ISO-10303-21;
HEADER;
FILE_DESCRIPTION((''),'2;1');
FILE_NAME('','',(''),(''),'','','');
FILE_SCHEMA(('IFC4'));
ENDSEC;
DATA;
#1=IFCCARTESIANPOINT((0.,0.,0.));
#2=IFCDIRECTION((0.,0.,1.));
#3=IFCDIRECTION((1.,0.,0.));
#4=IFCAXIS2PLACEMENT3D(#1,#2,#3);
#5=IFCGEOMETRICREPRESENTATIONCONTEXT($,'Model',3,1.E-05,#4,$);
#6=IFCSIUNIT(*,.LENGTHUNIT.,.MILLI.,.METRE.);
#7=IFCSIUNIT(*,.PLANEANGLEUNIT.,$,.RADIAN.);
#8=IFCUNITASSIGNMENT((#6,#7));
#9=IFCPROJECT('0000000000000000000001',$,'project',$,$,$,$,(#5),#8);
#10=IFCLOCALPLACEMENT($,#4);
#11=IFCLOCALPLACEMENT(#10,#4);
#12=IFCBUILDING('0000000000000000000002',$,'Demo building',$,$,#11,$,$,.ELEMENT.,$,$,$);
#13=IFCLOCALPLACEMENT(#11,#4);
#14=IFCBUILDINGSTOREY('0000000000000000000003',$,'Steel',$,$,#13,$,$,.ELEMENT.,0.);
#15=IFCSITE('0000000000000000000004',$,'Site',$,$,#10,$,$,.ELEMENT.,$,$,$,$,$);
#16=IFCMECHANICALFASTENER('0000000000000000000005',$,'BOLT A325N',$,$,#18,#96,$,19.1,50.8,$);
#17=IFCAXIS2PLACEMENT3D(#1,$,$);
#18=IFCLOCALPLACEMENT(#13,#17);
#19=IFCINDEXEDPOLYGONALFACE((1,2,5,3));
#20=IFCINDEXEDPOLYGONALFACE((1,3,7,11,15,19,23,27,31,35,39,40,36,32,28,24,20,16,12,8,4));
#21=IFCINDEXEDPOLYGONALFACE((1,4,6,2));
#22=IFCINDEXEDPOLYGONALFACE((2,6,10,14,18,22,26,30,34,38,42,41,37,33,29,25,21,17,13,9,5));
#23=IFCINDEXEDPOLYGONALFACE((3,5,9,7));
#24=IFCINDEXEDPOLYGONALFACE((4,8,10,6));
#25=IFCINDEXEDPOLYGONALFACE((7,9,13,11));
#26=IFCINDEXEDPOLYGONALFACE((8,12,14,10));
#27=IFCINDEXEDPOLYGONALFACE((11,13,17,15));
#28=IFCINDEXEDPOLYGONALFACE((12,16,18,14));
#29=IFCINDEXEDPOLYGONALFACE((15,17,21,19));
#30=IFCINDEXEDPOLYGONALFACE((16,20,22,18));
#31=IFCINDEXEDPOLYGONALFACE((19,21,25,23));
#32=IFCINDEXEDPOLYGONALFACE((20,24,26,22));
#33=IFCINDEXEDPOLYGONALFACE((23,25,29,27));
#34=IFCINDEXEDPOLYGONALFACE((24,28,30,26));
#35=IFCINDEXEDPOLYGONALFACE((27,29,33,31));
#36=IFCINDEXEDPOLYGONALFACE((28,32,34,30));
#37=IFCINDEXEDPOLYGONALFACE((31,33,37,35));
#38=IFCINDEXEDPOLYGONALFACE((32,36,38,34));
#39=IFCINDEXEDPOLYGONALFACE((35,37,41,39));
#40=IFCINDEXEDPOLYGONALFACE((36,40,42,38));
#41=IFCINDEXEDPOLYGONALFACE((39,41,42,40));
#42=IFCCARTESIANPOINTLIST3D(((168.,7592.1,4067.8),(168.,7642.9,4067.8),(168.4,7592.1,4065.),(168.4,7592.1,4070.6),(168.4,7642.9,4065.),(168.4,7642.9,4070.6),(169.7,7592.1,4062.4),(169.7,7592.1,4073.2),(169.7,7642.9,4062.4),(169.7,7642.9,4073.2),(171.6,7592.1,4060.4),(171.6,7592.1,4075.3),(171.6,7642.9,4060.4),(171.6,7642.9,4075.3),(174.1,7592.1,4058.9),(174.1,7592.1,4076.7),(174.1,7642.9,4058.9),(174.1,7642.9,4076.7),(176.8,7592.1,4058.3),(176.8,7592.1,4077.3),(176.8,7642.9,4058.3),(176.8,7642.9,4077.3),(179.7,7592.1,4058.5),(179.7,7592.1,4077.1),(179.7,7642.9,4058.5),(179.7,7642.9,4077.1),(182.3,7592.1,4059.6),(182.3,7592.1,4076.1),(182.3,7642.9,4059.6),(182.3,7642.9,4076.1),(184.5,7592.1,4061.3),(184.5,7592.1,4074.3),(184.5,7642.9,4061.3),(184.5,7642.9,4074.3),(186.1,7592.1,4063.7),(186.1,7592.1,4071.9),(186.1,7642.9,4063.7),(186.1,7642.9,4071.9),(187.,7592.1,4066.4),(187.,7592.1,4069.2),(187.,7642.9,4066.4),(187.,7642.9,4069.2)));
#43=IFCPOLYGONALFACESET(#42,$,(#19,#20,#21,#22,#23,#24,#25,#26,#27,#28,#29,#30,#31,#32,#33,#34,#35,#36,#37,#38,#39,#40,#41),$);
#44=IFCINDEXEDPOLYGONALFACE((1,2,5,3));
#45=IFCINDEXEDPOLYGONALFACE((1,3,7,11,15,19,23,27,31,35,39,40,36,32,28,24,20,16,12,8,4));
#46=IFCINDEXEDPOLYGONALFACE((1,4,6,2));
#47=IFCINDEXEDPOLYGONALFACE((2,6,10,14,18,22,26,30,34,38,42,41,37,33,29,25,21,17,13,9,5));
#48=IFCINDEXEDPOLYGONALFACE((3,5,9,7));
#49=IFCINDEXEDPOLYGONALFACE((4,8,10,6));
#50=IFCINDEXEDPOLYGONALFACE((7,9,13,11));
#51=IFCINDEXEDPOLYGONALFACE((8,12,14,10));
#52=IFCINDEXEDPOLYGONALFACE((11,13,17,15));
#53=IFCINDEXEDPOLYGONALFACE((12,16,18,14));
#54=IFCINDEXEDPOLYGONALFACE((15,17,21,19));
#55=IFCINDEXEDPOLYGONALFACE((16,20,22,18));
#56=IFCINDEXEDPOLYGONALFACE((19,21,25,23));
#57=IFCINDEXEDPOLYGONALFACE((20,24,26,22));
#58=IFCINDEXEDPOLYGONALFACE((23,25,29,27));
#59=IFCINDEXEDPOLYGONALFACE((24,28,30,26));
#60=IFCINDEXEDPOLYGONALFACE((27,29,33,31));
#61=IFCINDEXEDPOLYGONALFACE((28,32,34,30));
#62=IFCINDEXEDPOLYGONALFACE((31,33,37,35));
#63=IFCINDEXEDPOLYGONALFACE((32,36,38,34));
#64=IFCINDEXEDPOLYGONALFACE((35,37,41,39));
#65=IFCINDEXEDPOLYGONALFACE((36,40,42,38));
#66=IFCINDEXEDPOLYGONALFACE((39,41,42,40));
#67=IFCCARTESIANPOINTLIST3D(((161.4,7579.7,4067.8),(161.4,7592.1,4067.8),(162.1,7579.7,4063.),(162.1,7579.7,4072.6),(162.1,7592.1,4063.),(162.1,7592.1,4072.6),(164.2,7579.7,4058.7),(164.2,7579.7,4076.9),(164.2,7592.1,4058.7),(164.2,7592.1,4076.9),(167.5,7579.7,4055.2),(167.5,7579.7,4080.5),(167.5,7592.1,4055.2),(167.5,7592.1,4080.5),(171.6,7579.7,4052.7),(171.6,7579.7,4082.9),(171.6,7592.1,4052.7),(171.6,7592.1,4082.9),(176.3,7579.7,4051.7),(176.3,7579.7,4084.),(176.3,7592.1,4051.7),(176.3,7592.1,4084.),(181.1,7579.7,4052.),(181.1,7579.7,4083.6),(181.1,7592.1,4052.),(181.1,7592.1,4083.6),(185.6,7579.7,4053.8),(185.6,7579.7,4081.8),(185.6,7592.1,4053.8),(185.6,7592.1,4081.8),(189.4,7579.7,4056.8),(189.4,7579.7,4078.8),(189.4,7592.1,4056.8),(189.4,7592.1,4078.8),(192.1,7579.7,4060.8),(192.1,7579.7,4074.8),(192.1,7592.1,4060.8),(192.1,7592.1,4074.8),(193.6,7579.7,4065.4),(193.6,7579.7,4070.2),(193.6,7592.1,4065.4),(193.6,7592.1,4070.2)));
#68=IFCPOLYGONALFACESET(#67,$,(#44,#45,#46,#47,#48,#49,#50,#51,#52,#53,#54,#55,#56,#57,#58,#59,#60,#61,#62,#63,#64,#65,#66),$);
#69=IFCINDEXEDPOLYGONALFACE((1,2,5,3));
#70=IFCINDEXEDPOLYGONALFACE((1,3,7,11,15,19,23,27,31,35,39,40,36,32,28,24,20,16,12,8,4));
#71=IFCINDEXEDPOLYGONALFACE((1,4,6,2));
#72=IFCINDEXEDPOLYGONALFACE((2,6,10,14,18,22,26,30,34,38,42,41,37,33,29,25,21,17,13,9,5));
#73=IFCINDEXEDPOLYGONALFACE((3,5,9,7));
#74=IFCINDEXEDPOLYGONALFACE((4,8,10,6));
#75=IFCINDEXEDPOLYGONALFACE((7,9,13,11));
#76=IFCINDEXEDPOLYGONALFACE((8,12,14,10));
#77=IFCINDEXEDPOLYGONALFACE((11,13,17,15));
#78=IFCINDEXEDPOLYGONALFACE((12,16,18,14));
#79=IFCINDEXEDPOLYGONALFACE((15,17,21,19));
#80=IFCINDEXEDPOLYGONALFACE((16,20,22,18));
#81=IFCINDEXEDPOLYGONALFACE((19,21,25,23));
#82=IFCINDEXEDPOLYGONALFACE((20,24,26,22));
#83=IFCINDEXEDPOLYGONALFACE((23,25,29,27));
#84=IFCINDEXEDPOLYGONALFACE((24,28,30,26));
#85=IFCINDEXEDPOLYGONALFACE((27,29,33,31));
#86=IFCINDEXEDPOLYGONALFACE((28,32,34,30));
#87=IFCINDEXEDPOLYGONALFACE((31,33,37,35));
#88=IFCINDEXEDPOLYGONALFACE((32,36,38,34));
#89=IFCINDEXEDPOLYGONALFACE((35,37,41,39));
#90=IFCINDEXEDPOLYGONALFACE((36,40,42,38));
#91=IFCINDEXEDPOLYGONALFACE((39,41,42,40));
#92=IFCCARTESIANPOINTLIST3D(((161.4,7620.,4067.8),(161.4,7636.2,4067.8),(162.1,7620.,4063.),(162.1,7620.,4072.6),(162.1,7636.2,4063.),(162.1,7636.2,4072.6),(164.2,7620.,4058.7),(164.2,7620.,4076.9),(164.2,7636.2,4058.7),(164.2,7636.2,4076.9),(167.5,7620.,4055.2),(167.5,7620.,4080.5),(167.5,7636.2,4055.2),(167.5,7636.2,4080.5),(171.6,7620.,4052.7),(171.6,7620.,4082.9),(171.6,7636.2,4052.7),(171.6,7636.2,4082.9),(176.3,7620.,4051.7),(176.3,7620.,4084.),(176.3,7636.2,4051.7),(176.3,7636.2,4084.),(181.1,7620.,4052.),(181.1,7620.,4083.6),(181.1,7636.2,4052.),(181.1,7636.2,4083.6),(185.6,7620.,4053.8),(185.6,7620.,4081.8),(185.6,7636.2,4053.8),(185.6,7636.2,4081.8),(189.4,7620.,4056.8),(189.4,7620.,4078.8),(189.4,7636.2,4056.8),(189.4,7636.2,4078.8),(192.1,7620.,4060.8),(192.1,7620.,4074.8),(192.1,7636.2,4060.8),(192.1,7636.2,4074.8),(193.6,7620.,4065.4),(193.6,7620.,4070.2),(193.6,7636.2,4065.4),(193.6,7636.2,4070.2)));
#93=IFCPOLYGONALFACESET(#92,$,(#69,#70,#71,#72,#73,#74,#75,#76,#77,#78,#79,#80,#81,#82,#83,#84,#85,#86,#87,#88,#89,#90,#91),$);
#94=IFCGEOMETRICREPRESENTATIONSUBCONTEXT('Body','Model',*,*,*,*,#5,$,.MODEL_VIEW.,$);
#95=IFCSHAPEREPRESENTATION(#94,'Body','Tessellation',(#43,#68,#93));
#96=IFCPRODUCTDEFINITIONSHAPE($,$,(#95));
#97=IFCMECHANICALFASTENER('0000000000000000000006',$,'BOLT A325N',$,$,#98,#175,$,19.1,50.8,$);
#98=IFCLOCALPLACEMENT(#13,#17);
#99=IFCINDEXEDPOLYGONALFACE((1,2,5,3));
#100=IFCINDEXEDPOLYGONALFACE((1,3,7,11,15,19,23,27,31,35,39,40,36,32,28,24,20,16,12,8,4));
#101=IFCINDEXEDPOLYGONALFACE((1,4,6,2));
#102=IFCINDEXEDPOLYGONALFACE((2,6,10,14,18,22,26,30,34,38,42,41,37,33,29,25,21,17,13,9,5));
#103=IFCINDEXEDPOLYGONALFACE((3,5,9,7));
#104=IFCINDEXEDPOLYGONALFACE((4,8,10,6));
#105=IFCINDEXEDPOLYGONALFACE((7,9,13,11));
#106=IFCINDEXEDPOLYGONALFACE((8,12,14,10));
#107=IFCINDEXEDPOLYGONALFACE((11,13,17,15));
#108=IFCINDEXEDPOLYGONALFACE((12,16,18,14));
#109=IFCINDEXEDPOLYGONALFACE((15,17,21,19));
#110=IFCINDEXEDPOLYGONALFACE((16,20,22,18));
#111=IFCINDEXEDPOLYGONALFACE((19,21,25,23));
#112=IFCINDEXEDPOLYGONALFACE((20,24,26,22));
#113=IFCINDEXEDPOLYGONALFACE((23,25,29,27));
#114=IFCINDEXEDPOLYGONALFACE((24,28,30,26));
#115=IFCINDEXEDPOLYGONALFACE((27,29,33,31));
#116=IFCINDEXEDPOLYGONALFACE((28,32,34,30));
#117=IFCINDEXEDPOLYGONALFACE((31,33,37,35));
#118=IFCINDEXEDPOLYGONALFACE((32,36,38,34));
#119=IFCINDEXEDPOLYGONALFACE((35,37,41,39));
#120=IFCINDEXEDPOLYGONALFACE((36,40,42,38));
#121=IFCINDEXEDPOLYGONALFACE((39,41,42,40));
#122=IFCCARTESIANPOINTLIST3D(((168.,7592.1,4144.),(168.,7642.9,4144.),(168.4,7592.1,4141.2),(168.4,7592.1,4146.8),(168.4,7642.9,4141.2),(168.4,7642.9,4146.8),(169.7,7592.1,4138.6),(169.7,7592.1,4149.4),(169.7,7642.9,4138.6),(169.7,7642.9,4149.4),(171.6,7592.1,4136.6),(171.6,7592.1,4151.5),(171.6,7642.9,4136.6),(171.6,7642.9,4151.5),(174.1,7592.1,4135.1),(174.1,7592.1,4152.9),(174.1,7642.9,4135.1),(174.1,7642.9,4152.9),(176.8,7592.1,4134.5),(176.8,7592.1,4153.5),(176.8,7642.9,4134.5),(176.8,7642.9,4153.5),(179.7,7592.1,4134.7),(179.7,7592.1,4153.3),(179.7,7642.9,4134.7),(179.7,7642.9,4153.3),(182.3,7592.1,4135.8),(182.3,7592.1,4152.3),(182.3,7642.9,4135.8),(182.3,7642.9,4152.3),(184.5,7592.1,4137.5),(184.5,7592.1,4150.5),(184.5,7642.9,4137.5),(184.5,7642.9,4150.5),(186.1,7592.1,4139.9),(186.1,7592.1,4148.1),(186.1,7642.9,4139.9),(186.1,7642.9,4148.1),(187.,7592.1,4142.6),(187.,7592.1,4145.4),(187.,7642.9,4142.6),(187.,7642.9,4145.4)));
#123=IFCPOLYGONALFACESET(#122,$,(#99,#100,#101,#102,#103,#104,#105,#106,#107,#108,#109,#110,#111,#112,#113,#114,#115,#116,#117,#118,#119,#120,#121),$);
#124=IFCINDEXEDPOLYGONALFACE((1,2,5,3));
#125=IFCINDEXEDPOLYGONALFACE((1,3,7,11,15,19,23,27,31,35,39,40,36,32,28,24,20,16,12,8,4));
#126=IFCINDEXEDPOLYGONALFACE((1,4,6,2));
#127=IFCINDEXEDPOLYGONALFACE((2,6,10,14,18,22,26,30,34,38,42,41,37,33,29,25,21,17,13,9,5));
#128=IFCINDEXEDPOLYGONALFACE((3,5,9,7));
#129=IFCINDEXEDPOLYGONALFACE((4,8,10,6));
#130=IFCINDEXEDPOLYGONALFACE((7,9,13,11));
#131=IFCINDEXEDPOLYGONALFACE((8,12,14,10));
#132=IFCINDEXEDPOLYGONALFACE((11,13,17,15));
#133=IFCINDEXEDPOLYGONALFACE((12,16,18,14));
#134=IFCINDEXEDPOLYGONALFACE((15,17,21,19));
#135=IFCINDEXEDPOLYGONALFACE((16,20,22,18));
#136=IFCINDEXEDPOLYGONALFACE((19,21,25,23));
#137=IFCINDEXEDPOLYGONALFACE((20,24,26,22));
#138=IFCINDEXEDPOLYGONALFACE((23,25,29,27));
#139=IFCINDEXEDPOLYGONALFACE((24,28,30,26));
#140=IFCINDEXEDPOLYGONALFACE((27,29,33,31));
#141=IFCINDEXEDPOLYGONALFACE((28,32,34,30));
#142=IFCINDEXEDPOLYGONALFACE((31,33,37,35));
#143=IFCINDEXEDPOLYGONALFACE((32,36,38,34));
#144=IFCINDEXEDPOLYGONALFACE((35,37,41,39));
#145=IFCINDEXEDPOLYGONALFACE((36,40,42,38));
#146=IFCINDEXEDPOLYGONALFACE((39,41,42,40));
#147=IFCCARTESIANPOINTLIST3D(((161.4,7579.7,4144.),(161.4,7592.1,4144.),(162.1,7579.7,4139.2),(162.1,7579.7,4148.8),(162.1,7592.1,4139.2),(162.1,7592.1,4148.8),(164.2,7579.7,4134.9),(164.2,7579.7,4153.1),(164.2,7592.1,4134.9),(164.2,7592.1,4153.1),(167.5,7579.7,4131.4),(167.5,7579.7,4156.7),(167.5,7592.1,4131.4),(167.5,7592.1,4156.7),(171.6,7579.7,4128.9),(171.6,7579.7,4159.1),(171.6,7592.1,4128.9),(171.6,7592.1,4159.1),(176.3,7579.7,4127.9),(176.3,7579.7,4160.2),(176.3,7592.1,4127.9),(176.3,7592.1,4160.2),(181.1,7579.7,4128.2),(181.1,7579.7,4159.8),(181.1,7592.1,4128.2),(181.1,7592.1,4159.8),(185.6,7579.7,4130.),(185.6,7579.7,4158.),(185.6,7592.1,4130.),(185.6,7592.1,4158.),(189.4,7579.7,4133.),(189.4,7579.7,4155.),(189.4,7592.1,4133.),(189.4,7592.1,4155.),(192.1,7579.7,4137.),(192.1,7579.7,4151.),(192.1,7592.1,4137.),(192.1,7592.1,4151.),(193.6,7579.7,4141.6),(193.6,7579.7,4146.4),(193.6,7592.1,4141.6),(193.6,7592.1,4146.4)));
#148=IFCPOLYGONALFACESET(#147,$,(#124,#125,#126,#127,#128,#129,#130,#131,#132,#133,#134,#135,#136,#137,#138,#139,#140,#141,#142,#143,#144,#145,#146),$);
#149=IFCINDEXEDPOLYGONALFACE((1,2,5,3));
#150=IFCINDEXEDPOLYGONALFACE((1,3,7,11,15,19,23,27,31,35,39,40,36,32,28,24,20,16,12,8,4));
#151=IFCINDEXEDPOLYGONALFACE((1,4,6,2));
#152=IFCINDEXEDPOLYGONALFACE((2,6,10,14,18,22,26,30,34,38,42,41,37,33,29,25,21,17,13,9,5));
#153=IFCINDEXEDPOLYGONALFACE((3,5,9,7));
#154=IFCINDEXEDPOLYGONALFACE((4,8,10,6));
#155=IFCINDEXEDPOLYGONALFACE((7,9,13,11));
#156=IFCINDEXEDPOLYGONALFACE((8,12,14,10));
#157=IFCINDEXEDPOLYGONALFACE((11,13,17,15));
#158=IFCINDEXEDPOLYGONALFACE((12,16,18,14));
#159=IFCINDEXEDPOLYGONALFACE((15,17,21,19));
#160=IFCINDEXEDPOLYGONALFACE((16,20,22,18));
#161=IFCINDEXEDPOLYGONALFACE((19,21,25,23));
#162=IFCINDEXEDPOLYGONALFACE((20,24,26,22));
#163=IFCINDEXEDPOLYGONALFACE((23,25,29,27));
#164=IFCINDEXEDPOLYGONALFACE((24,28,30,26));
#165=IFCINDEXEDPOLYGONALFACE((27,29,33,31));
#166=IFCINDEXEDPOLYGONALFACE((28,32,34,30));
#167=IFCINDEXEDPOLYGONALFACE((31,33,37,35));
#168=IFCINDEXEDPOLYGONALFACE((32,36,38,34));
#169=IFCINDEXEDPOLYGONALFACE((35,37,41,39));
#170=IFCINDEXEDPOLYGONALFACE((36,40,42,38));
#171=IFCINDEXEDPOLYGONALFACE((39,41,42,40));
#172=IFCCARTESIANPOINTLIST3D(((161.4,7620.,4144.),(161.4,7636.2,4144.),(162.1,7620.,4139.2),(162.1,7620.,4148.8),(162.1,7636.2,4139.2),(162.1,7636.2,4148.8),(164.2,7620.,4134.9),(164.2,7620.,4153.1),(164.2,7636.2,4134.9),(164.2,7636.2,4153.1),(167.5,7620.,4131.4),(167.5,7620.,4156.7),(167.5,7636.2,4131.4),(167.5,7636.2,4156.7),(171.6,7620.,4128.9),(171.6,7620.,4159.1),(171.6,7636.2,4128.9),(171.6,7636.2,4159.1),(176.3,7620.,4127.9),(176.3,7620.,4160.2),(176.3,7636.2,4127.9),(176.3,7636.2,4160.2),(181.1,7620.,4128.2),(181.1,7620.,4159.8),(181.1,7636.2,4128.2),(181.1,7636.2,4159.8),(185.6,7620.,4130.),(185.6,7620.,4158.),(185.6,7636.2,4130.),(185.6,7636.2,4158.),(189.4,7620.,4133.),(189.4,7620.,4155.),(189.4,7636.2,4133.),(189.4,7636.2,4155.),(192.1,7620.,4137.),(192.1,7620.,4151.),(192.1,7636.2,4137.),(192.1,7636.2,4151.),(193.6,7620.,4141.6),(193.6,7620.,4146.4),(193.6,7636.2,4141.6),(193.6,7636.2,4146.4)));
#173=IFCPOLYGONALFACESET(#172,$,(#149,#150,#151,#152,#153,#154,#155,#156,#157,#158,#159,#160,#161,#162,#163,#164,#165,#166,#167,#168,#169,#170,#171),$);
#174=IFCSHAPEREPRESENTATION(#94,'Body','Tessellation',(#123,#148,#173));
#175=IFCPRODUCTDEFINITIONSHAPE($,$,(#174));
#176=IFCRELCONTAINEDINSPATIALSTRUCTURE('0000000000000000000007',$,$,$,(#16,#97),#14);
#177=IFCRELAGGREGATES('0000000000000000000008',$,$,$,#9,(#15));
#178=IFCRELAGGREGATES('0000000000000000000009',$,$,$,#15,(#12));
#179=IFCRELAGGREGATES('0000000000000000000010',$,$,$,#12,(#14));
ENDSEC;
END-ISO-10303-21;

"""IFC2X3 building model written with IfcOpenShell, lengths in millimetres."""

from ifc_helpers import new_model, si_unit, frame, origin, origin_with_axes, origin_2d, place, context, subcontext, project, spatial, circle, extrude, element, save


model = new_model("IFC2X3")

# Units and contexts
model_context = context("Model", 3, precision=1e-05, world=origin_with_axes())
body_context = subcontext(model_context, "Body", "Model", "MODEL_VIEW")
ifc_project = project(units=[si_unit("LENGTHUNIT", "METRE", prefix="MILLI"), si_unit("PLANEANGLEUNIT", "RADIAN")], contexts=[model_context])

# Site, building, storey
site_placement = place(None, origin_with_axes())
site = spatial("IfcSite", under=ifc_project, at=site_placement, Name="Site", CompositionType="ELEMENT")
building_placement = place(site_placement, origin_with_axes())
building = spatial("IfcBuilding", under=site, at=building_placement, Name="Demo building", CompositionType="ELEMENT")
placement = place(building_placement, origin_with_axes())
storey = spatial("IfcBuildingStorey", under=building, at=placement, Name="Steel", CompositionType="ELEMENT", Elevation=0.0)

# Mechanical fasteners
for number, where, z_axis, x_axis, name in (
    (1, (177.5, 7592.1, 4067.8), (0.0, 1.0, 0.0), (-1.0, 0.0, 0.0), "BOLT A325N"),
    (2, (177.5, 7592.1, 4144.0), (0.0, 1.0, 0.0), (-1.0, 0.0, 0.0), "BOLT A325N"),
):
    element("IfcMechanicalFastener", number, at=place(placement, frame(where, z_axis=z_axis, x_axis=x_axis)), inside=storey, Name=name, NominalDiameter=19.1, NominalLength=50.8, context=body_context, shape_type="SweptSolid", body=[
        extrude(circle(Radius=9.5, at=origin_2d()), origin(), (0.0, 0.0, 1.0), 50.8),
        extrude(circle(Radius=16.2, at=origin_2d()), frame((0.0, 0.0, -12.4)), (0.0, 0.0, 1.0), 12.4),
        extrude(circle(Radius=16.2, at=origin_2d()), frame((0.0, 0.0, 27.9)), (0.0, 0.0, 1.0), 16.2),
    ])

save(model, "model.ifc")
